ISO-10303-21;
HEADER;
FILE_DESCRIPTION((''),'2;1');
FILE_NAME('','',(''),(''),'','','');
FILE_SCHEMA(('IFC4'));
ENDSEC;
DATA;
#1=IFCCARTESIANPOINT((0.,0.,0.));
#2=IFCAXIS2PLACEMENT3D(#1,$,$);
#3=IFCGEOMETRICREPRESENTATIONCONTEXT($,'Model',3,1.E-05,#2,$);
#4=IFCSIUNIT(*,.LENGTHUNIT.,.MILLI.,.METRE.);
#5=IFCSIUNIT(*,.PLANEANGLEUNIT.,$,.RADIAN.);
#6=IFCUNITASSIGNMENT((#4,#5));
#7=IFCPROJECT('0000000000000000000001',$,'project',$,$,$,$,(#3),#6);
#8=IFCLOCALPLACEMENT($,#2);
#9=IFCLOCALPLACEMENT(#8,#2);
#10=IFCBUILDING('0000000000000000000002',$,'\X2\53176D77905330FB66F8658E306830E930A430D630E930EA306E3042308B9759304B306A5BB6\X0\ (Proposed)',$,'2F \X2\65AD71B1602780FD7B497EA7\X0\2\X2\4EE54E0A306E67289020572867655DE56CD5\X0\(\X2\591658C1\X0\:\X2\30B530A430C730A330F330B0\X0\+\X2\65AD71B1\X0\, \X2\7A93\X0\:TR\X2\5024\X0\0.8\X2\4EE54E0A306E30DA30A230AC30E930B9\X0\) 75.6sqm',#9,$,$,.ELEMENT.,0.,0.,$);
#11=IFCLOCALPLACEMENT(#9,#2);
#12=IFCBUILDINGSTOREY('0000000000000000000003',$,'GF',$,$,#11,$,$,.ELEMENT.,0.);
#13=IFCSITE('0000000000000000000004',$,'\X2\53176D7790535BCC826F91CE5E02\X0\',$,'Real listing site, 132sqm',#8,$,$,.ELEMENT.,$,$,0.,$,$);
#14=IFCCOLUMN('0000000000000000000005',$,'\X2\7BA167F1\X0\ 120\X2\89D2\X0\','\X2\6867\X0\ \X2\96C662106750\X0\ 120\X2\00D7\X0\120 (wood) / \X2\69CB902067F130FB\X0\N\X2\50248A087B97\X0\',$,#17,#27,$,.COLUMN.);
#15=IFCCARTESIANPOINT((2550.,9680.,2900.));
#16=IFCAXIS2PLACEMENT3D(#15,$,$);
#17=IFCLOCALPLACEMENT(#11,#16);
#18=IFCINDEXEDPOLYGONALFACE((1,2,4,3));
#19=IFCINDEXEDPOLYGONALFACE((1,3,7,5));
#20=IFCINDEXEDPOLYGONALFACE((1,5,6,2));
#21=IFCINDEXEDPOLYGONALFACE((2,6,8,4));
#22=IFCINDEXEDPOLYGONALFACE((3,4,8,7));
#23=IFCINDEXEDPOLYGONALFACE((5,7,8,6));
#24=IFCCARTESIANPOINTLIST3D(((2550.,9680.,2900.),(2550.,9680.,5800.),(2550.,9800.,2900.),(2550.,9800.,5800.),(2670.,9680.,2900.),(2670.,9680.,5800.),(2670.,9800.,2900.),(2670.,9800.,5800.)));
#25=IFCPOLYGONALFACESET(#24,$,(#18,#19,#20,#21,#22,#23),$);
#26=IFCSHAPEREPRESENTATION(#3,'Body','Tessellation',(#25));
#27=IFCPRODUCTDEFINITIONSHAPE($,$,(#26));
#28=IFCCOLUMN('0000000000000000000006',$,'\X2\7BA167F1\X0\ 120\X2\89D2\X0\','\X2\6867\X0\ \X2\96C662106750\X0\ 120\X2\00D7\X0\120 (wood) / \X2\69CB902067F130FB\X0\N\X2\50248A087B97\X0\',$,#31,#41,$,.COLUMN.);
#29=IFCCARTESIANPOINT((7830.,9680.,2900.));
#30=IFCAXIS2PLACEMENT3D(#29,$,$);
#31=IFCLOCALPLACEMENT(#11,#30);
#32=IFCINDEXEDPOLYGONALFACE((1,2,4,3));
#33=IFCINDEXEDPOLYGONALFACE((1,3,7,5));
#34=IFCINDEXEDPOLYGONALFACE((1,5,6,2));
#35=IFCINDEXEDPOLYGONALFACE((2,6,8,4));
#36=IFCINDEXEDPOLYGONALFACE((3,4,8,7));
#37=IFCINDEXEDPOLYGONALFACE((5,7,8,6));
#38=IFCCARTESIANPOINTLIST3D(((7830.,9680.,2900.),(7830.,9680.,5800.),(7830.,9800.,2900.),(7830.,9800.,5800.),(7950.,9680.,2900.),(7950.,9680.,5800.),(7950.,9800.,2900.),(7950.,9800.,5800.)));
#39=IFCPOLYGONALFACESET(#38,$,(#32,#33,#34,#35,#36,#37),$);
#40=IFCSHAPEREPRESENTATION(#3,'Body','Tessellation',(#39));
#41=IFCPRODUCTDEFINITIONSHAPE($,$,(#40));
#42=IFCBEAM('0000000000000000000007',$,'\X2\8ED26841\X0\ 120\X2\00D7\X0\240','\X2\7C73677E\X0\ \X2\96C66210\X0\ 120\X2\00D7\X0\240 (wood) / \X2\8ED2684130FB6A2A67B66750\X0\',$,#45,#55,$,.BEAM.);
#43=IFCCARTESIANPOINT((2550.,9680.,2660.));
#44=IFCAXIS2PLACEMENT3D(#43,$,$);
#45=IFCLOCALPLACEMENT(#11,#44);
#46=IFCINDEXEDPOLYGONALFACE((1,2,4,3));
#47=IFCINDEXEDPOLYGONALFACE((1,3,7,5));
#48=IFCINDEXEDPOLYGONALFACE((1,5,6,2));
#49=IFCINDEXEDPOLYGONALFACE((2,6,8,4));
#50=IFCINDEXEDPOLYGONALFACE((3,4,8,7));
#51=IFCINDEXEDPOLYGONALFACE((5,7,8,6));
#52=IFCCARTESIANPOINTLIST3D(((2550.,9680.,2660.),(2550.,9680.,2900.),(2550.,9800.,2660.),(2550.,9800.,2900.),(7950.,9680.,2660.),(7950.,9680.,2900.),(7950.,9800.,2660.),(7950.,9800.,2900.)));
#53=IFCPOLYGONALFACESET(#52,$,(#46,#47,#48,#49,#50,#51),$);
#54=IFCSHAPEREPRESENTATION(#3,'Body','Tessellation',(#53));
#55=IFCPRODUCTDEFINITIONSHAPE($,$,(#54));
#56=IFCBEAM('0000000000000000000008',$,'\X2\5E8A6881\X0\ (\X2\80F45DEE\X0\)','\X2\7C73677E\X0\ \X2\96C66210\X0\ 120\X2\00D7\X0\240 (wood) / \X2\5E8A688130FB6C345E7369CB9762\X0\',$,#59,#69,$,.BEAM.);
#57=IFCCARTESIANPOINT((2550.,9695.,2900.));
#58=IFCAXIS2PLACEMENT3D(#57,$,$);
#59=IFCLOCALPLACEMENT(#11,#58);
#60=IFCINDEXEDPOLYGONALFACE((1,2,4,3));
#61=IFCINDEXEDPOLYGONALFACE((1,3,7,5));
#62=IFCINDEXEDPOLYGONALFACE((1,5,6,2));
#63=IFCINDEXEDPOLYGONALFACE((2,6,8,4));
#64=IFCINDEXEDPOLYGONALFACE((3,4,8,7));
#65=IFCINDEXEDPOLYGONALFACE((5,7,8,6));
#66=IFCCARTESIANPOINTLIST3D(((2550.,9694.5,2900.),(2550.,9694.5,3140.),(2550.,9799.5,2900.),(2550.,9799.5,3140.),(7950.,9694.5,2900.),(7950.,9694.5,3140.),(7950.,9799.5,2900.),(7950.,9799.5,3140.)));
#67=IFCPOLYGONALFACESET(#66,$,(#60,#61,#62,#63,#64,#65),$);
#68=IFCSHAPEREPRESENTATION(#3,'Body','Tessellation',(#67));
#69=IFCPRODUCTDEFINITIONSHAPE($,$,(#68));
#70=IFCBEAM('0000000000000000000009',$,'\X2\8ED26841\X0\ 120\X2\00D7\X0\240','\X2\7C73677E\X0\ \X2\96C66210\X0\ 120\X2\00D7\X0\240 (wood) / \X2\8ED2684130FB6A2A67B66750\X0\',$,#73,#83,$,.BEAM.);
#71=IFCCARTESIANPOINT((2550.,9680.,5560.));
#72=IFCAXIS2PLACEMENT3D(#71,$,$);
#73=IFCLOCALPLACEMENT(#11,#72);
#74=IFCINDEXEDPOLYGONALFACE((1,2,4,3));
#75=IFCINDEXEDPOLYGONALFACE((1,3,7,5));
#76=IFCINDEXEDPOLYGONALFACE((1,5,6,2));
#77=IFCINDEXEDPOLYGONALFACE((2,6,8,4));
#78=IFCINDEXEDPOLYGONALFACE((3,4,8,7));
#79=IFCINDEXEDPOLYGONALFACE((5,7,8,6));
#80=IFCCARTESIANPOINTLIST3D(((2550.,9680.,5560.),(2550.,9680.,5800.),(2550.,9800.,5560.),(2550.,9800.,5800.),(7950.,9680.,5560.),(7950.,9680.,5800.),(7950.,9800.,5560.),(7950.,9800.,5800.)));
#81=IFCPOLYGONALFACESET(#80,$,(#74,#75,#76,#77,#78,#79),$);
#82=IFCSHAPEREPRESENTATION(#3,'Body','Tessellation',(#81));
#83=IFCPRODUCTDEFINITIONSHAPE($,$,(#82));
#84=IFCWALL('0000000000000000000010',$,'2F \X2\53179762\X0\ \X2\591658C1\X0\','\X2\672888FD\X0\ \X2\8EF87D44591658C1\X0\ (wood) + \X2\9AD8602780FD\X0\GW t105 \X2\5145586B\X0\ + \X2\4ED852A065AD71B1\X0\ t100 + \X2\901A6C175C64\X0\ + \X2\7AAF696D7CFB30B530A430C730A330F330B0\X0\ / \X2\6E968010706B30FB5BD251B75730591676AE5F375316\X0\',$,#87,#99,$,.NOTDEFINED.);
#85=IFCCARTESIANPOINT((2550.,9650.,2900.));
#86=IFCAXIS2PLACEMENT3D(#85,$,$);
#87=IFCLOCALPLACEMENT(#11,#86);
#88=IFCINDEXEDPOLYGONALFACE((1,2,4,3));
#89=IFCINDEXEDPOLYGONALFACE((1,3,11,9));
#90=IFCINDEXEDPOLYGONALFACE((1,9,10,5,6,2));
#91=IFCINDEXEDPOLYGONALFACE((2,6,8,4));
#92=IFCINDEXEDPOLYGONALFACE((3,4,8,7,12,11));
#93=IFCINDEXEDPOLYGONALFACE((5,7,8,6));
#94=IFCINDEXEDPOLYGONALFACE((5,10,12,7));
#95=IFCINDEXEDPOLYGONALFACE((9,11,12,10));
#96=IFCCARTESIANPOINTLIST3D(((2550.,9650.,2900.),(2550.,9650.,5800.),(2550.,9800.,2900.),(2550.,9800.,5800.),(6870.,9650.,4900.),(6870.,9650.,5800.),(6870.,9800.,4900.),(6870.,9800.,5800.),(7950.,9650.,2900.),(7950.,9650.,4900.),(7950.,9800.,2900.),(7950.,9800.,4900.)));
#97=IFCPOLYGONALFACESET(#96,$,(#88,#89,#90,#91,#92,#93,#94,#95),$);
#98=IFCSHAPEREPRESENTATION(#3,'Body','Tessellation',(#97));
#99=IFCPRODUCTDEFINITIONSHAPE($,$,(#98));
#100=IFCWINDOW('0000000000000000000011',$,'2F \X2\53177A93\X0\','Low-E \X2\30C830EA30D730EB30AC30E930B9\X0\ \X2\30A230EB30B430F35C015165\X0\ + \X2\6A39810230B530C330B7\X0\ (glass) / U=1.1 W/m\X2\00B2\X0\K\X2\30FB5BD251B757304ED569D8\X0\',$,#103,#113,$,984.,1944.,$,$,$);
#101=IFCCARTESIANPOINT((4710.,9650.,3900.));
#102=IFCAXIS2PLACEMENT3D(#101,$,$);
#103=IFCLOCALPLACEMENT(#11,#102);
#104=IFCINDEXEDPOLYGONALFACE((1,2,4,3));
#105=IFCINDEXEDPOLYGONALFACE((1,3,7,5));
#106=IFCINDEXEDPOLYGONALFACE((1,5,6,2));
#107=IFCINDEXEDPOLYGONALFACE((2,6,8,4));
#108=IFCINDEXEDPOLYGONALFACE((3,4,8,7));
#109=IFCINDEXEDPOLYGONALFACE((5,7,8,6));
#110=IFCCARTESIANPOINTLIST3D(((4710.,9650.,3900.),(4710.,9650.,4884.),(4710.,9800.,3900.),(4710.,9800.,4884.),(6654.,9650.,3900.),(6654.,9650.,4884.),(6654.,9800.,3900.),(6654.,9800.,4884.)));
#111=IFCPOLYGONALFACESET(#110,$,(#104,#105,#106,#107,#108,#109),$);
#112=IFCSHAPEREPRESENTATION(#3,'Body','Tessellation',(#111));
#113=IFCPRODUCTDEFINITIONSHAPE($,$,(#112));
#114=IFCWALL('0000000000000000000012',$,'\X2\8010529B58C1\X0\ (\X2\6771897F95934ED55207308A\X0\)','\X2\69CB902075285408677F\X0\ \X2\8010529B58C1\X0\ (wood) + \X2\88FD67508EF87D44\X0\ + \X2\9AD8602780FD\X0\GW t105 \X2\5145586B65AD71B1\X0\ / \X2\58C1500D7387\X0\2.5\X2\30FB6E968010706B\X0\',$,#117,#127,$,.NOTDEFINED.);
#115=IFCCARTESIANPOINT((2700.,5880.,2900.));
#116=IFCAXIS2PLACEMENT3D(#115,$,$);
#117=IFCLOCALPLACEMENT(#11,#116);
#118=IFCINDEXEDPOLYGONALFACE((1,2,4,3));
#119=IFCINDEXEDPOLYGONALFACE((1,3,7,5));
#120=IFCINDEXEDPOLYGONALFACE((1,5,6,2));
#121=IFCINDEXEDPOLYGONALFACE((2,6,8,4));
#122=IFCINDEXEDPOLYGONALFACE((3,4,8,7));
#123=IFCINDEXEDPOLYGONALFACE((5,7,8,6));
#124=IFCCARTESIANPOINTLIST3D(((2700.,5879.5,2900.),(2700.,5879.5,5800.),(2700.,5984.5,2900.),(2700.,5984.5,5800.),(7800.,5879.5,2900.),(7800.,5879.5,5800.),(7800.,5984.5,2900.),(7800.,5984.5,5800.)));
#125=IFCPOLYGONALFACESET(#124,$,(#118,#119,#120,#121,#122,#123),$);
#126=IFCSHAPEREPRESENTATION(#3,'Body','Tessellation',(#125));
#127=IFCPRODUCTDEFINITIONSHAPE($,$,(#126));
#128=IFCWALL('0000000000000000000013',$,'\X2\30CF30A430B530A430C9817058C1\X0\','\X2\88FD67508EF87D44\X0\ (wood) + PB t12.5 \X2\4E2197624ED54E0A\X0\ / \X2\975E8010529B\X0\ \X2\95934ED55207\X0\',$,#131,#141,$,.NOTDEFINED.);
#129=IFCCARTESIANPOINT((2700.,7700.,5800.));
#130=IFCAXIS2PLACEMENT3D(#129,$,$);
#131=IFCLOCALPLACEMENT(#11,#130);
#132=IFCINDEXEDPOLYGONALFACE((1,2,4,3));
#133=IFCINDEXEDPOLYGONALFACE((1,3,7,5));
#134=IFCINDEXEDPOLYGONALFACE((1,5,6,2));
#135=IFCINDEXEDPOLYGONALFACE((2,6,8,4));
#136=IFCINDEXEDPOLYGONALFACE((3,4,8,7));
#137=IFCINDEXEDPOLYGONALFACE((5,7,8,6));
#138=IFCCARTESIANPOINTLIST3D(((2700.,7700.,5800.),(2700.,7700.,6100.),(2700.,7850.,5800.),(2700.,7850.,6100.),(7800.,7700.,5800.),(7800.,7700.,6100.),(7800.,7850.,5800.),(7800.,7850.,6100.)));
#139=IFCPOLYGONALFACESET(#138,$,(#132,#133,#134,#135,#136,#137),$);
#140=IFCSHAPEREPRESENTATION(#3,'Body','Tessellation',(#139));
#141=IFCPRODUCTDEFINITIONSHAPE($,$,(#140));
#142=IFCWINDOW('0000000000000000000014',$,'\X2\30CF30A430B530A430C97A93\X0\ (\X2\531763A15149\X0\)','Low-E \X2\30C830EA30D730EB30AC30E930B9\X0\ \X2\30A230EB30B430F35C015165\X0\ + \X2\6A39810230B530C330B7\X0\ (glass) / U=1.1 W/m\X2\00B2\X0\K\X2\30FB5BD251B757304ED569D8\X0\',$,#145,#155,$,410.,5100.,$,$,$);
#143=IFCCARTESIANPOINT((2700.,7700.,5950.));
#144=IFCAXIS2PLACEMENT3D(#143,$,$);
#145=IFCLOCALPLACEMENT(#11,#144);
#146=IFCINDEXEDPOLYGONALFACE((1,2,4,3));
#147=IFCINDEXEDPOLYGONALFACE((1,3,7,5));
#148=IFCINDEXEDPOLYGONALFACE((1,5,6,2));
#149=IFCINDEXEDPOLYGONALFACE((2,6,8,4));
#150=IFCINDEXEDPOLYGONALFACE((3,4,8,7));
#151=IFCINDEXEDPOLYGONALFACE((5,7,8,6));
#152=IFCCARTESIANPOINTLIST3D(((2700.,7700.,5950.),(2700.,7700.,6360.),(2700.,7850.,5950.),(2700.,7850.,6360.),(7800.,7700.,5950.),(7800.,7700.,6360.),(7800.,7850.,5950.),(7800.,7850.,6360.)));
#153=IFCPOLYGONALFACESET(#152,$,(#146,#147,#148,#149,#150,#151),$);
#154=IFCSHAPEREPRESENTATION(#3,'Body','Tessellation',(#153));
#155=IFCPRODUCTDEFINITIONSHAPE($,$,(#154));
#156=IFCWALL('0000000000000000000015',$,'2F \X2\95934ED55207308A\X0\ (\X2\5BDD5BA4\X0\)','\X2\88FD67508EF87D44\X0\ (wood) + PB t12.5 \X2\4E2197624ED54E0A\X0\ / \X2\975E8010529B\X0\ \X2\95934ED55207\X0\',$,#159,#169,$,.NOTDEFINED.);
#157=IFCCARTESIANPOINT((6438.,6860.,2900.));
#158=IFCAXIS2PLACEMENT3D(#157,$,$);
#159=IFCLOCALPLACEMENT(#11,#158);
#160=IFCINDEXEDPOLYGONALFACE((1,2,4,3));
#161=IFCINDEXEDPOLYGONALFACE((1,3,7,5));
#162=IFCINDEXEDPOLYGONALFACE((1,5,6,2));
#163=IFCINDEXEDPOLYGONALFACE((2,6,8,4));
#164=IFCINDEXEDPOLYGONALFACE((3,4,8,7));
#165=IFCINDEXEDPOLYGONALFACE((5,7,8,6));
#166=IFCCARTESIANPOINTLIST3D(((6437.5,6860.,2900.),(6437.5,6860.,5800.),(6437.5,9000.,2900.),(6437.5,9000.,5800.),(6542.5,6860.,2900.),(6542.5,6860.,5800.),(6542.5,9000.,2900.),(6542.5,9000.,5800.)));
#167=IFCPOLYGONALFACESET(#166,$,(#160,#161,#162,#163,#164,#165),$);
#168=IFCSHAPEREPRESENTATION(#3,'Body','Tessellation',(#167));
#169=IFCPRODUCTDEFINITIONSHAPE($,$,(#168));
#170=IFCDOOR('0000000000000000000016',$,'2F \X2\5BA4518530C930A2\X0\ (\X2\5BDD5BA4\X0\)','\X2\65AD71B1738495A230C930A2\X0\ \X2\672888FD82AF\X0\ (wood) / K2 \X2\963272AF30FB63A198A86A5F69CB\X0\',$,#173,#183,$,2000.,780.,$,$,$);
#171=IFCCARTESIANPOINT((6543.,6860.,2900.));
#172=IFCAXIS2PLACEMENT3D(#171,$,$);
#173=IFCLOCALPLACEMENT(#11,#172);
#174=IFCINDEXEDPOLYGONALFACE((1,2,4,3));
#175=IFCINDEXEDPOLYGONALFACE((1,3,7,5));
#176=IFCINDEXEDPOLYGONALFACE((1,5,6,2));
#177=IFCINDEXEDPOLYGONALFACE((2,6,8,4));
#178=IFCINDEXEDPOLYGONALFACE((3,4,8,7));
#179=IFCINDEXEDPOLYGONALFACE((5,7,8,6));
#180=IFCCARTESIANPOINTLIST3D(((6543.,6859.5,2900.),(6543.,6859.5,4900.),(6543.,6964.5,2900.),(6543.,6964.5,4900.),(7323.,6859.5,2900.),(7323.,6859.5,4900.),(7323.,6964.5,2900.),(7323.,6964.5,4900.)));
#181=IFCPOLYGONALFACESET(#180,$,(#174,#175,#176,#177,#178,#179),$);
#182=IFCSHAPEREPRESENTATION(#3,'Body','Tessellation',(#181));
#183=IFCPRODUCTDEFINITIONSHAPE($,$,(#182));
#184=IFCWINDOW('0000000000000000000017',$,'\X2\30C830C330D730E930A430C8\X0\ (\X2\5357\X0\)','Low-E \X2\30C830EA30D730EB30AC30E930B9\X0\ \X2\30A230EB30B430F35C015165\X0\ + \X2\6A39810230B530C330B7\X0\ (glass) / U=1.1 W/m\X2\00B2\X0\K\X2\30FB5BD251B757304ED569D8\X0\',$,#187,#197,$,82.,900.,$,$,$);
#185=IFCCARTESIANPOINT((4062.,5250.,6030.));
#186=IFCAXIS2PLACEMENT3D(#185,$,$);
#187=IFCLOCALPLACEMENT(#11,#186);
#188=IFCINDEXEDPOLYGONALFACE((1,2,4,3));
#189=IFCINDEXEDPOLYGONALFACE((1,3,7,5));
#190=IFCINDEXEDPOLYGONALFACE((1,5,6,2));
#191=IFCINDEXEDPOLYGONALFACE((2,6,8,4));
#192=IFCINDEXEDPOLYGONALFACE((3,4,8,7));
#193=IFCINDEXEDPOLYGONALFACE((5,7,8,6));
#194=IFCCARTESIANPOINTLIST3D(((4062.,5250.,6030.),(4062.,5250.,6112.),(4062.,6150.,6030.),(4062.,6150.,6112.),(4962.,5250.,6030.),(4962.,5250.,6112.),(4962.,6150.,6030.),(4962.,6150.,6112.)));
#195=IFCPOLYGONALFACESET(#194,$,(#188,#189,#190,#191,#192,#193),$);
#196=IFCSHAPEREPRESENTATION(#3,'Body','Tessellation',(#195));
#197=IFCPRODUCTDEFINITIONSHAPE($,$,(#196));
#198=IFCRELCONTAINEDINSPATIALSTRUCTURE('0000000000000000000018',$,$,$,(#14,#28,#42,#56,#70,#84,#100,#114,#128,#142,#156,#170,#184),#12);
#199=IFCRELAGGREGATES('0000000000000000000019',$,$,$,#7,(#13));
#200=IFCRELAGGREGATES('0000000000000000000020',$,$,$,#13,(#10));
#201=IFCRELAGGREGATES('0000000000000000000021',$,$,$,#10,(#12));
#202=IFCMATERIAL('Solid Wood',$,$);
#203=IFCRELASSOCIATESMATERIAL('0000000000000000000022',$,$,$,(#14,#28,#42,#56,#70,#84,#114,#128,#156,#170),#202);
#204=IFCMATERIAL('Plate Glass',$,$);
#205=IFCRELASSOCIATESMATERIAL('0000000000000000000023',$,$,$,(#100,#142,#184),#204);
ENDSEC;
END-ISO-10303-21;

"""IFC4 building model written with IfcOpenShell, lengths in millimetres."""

from ifc_helpers import new_model, si_unit, frame, frame_2d, origin, place, context, project, spatial, rectangle, extrude, material, element, fill, save


model = new_model("IFC4")

# Units and contexts
model_context = context("Model", 3, precision=1e-05, world=origin())
ifc_project = project(units=[si_unit("LENGTHUNIT", "METRE", prefix="MILLI"), si_unit("PLANEANGLEUNIT", "RADIAN")], contexts=[model_context])

# Site, building, storey
site_placement = place(None, origin())
site = spatial("IfcSite", under=ifc_project, at=site_placement, Name="北海道富良野市", ObjectType="Real listing site, 132sqm", CompositionType="ELEMENT", RefElevation=0.0)
building_placement = place(site_placement, origin())
building = spatial("IfcBuilding", under=site, at=building_placement, Name="北海道・書斎とライブラリのある静かな家 (Proposed)", ObjectType="2F 断熱性能等级2以上の木造在来工法(外壁:サイディング+断熱, 窓:TR値0.8以上のペアガラス) 75.6sqm", CompositionType="ELEMENT", ElevationOfRefHeight=0.0, ElevationOfTerrain=0.0)
storey_placement = place(building_placement, origin())
storey = spatial("IfcBuildingStorey", under=building, at=storey_placement, Name="GF", CompositionType="ELEMENT", Elevation=0.0)

# Columns
ifc_material_1 = material(Name="Solid Wood")
column_1_placement = place(storey_placement, frame((2550.0, 9680.0, 2900.0)))
element("IfcColumn", 1, at=column_1_placement, inside=storey, material=ifc_material_1, Name="管柱 120角", Description="桧 集成材 120×120 (wood) / 構造柱・N値計算", PredefinedType="COLUMN", context=model_context, shape_type="SweptSolid", body=[
    extrude(rectangle(XDim=120.0, YDim=120.0, at=frame_2d((60.0, 60.0))), frame((2550.0, 9680.0, 2900.0)), (0.0, 0.0, 1.0), 2900.0),
])
column_2_placement = place(storey_placement, frame((7830.0, 9680.0, 2900.0)))
element("IfcColumn", 2, at=column_2_placement, inside=storey, material=ifc_material_1, Name="管柱 120角", Description="桧 集成材 120×120 (wood) / 構造柱・N値計算", PredefinedType="COLUMN", context=model_context, shape_type="SweptSolid", body=[
    extrude(rectangle(XDim=120.0, YDim=120.0, at=frame_2d((60.0, 60.0))), frame((7830.0, 9680.0, 2900.0)), (0.0, 0.0, 1.0), 2900.0),
])

# Beams
beam_1_placement = place(storey_placement, frame((2550.0, 9680.0, 2660.0)))
element("IfcBeam", 3, at=beam_1_placement, inside=storey, material=ifc_material_1, Name="軒桁 120×240", Description="米松 集成 120×240 (wood) / 軒桁・横架材", PredefinedType="BEAM", context=model_context, shape_type="SweptSolid", body=[
    extrude(rectangle(XDim=5400.0, YDim=120.0, at=frame_2d((2700.0, 60.0))), frame((2550.0, 9680.0, 2660.0)), (0.0, 0.0, 1.0), 240.0),
])
beam_2_placement = place(storey_placement, frame((2550.0, 9695.0, 2900.0)))
element("IfcBeam", 4, at=beam_2_placement, inside=storey, material=ifc_material_1, Name="床梁 (胴差)", Description="米松 集成 120×240 (wood) / 床梁・水平構面", PredefinedType="BEAM", context=model_context, shape_type="SweptSolid", body=[
    extrude(rectangle(XDim=5400.0, YDim=105.0, at=frame_2d((2700.0, 52.0))), frame((2550.0, 9695.0, 2900.0)), (0.0, 0.0, 1.0), 240.0),
])
beam_3_placement = place(storey_placement, frame((2550.0, 9680.0, 5560.0)))
element("IfcBeam", 5, at=beam_3_placement, inside=storey, material=ifc_material_1, Name="軒桁 120×240", Description="米松 集成 120×240 (wood) / 軒桁・横架材", PredefinedType="BEAM", context=model_context, shape_type="SweptSolid", body=[
    extrude(rectangle(XDim=5400.0, YDim=120.0, at=frame_2d((2700.0, 60.0))), frame((2550.0, 9680.0, 5560.0)), (0.0, 0.0, 1.0), 240.0),
])

# Wall, opening, window
wall_1_placement = place(storey_placement, frame((2550.0, 9650.0, 2900.0)))
wall_1 = element("IfcWall", 6, at=wall_1_placement, inside=storey, material=ifc_material_1, Name="2F 北面 外壁", Description="木製 軸組外壁 (wood) + 高性能GW t105 充填 + 付加断熱 t100 + 通気層 + 窯業系サイディング / 準耐火・寒冷地外皮強化", PredefinedType="NOTDEFINED", context=model_context, shape_type="SweptSolid", body=[
    extrude(rectangle(XDim=5400.0, YDim=150.0, at=frame_2d((2700.0, 75.0))), frame((2550.0, 9650.0, 2900.0)), (0.0, 0.0, 1.0), 2900.0),
])
opening_1_placement = place(storey_placement, frame((4710.0, 9650.0, 3900.0)))
opening_1 = element("IfcOpeningElement", 7, at=opening_1_placement, cuts=wall_1, PredefinedType="NOTDEFINED", context=model_context, shape_type="SweptSolid", body=[
    extrude(rectangle(XDim=1944.0, YDim=150.0, at=frame_2d((972.0, 75.0))), frame((4710.0, 9650.0, 3900.0)), (0.0, 0.0, 1.0), 984.0),
])
ifc_material_2 = material(Name="Plate Glass")
window_1_placement = place(storey_placement, frame((4710.0, 9650.0, 3900.0)))
window_1 = element("IfcWindow", 8, at=window_1_placement, inside=storey, material=ifc_material_2, Name="2F 北窓", Description="Low-E トリプルガラス アルゴン封入 + 樹脂サッシ (glass) / U=1.1 W/m²K・寒冷地仕様", OverallHeight=984.0, OverallWidth=1944.0, context=model_context, shape_type="SweptSolid", body=[
    extrude(rectangle(XDim=1944.0, YDim=150.0, at=frame_2d((972.0, 75.0))), frame((4710.0, 9650.0, 3900.0)), (0.0, 0.0, 1.0), 984.0),
])
fill(opening_1, window_1)

# Wall
wall_2_placement = place(storey_placement, frame((2700.0, 5880.0, 2900.0)))
element("IfcWall", 9, at=wall_2_placement, inside=storey, material=ifc_material_1, Name="耐力壁 (東西間仕切り)", Description="構造用合板 耐力壁 (wood) + 製材軸組 + 高性能GW t105 充填断熱 / 壁倍率2.5・準耐火", PredefinedType="NOTDEFINED", context=model_context, shape_type="SweptSolid", body=[
    extrude(rectangle(XDim=5100.0, YDim=105.0, at=frame_2d((2550.0, 52.0))), frame((2700.0, 5880.0, 2900.0)), (0.0, 0.0, 1.0), 2900.0),
])

# Wall, opening, window
wall_3_placement = place(storey_placement, frame((2700.0, 7700.0, 5800.0)))
wall_3 = element("IfcWall", 10, at=wall_3_placement, inside=storey, material=ifc_material_1, Name="ハイサイド腰壁", Description="製材軸組 (wood) + PB t12.5 両面仕上 / 非耐力 間仕切", PredefinedType="NOTDEFINED", context=model_context, shape_type="SweptSolid", body=[
    extrude(rectangle(XDim=5100.0, YDim=150.0, at=frame_2d((2550.0, 75.0))), frame((2700.0, 7700.0, 5800.0)), (0.0, 0.0, 1.0), 700.0),
])
opening_2_placement = place(storey_placement, frame((2700.0, 7700.0, 5950.0)))
opening_2 = element("IfcOpeningElement", 11, at=opening_2_placement, cuts=wall_3, PredefinedType="NOTDEFINED", context=model_context, shape_type="SweptSolid", body=[
    extrude(rectangle(XDim=5100.0, YDim=150.0, at=frame_2d((2550.0, 75.0))), frame((2700.0, 7700.0, 5950.0)), (0.0, 0.0, 1.0), 410.0),
])
window_2_placement = place(storey_placement, frame((2700.0, 7700.0, 5950.0)))
window_2 = element("IfcWindow", 12, at=window_2_placement, inside=storey, material=ifc_material_2, Name="ハイサイド窓 (北採光)", Description="Low-E トリプルガラス アルゴン封入 + 樹脂サッシ (glass) / U=1.1 W/m²K・寒冷地仕様", OverallHeight=410.0, OverallWidth=5100.0, context=model_context, shape_type="SweptSolid", body=[
    extrude(rectangle(XDim=5100.0, YDim=150.0, at=frame_2d((2550.0, 75.0))), frame((2700.0, 7700.0, 5950.0)), (0.0, 0.0, 1.0), 410.0),
])
fill(opening_2, window_2)

# Wall
wall_4_placement = place(storey_placement, frame((6438.0, 6860.0, 2900.0)))
element("IfcWall", 13, at=wall_4_placement, inside=storey, material=ifc_material_1, Name="2F 間仕切り (寝室)", Description="製材軸組 (wood) + PB t12.5 両面仕上 / 非耐力 間仕切", PredefinedType="NOTDEFINED", context=model_context, shape_type="SweptSolid", body=[
    extrude(rectangle(XDim=105.0, YDim=2140.0, at=frame_2d((52.0, 1070.0))), frame((6438.0, 6860.0, 2900.0)), (0.0, 0.0, 1.0), 2900.0),
])

# Door
door_placement = place(storey_placement, frame((6543.0, 6860.0, 2900.0)))
element("IfcDoor", 14, at=door_placement, inside=storey, material=ifc_material_1, Name="2F 室内ドア (寝室)", Description="断熱玄関ドア 木製芯 (wood) / K2 防犯・採風機構", OverallHeight=2000.0, OverallWidth=780.0, context=model_context, shape_type="SweptSolid", body=[
    extrude(rectangle(XDim=780.0, YDim=105.0, at=frame_2d((390.0, 52.0))), frame((6543.0, 6860.0, 2900.0)), (0.0, 0.0, 1.0), 2000.0),
])

# Window
window_3_placement = place(storey_placement, frame((4062.0, 5250.0, 6030.0)))
element("IfcWindow", 15, at=window_3_placement, inside=storey, material=ifc_material_2, Name="トップライト (南)", Description="Low-E トリプルガラス アルゴン封入 + 樹脂サッシ (glass) / U=1.1 W/m²K・寒冷地仕様", OverallHeight=82.0, OverallWidth=900.0, context=model_context, shape_type="SweptSolid", body=[
    extrude(rectangle(XDim=900.0, YDim=900.0, at=frame_2d((450.0, 450.0))), frame((4062.0, 5250.0, 6030.0)), (0.0, 0.0, 1.0), 82.0),
])

save(model, "model.ifc")
